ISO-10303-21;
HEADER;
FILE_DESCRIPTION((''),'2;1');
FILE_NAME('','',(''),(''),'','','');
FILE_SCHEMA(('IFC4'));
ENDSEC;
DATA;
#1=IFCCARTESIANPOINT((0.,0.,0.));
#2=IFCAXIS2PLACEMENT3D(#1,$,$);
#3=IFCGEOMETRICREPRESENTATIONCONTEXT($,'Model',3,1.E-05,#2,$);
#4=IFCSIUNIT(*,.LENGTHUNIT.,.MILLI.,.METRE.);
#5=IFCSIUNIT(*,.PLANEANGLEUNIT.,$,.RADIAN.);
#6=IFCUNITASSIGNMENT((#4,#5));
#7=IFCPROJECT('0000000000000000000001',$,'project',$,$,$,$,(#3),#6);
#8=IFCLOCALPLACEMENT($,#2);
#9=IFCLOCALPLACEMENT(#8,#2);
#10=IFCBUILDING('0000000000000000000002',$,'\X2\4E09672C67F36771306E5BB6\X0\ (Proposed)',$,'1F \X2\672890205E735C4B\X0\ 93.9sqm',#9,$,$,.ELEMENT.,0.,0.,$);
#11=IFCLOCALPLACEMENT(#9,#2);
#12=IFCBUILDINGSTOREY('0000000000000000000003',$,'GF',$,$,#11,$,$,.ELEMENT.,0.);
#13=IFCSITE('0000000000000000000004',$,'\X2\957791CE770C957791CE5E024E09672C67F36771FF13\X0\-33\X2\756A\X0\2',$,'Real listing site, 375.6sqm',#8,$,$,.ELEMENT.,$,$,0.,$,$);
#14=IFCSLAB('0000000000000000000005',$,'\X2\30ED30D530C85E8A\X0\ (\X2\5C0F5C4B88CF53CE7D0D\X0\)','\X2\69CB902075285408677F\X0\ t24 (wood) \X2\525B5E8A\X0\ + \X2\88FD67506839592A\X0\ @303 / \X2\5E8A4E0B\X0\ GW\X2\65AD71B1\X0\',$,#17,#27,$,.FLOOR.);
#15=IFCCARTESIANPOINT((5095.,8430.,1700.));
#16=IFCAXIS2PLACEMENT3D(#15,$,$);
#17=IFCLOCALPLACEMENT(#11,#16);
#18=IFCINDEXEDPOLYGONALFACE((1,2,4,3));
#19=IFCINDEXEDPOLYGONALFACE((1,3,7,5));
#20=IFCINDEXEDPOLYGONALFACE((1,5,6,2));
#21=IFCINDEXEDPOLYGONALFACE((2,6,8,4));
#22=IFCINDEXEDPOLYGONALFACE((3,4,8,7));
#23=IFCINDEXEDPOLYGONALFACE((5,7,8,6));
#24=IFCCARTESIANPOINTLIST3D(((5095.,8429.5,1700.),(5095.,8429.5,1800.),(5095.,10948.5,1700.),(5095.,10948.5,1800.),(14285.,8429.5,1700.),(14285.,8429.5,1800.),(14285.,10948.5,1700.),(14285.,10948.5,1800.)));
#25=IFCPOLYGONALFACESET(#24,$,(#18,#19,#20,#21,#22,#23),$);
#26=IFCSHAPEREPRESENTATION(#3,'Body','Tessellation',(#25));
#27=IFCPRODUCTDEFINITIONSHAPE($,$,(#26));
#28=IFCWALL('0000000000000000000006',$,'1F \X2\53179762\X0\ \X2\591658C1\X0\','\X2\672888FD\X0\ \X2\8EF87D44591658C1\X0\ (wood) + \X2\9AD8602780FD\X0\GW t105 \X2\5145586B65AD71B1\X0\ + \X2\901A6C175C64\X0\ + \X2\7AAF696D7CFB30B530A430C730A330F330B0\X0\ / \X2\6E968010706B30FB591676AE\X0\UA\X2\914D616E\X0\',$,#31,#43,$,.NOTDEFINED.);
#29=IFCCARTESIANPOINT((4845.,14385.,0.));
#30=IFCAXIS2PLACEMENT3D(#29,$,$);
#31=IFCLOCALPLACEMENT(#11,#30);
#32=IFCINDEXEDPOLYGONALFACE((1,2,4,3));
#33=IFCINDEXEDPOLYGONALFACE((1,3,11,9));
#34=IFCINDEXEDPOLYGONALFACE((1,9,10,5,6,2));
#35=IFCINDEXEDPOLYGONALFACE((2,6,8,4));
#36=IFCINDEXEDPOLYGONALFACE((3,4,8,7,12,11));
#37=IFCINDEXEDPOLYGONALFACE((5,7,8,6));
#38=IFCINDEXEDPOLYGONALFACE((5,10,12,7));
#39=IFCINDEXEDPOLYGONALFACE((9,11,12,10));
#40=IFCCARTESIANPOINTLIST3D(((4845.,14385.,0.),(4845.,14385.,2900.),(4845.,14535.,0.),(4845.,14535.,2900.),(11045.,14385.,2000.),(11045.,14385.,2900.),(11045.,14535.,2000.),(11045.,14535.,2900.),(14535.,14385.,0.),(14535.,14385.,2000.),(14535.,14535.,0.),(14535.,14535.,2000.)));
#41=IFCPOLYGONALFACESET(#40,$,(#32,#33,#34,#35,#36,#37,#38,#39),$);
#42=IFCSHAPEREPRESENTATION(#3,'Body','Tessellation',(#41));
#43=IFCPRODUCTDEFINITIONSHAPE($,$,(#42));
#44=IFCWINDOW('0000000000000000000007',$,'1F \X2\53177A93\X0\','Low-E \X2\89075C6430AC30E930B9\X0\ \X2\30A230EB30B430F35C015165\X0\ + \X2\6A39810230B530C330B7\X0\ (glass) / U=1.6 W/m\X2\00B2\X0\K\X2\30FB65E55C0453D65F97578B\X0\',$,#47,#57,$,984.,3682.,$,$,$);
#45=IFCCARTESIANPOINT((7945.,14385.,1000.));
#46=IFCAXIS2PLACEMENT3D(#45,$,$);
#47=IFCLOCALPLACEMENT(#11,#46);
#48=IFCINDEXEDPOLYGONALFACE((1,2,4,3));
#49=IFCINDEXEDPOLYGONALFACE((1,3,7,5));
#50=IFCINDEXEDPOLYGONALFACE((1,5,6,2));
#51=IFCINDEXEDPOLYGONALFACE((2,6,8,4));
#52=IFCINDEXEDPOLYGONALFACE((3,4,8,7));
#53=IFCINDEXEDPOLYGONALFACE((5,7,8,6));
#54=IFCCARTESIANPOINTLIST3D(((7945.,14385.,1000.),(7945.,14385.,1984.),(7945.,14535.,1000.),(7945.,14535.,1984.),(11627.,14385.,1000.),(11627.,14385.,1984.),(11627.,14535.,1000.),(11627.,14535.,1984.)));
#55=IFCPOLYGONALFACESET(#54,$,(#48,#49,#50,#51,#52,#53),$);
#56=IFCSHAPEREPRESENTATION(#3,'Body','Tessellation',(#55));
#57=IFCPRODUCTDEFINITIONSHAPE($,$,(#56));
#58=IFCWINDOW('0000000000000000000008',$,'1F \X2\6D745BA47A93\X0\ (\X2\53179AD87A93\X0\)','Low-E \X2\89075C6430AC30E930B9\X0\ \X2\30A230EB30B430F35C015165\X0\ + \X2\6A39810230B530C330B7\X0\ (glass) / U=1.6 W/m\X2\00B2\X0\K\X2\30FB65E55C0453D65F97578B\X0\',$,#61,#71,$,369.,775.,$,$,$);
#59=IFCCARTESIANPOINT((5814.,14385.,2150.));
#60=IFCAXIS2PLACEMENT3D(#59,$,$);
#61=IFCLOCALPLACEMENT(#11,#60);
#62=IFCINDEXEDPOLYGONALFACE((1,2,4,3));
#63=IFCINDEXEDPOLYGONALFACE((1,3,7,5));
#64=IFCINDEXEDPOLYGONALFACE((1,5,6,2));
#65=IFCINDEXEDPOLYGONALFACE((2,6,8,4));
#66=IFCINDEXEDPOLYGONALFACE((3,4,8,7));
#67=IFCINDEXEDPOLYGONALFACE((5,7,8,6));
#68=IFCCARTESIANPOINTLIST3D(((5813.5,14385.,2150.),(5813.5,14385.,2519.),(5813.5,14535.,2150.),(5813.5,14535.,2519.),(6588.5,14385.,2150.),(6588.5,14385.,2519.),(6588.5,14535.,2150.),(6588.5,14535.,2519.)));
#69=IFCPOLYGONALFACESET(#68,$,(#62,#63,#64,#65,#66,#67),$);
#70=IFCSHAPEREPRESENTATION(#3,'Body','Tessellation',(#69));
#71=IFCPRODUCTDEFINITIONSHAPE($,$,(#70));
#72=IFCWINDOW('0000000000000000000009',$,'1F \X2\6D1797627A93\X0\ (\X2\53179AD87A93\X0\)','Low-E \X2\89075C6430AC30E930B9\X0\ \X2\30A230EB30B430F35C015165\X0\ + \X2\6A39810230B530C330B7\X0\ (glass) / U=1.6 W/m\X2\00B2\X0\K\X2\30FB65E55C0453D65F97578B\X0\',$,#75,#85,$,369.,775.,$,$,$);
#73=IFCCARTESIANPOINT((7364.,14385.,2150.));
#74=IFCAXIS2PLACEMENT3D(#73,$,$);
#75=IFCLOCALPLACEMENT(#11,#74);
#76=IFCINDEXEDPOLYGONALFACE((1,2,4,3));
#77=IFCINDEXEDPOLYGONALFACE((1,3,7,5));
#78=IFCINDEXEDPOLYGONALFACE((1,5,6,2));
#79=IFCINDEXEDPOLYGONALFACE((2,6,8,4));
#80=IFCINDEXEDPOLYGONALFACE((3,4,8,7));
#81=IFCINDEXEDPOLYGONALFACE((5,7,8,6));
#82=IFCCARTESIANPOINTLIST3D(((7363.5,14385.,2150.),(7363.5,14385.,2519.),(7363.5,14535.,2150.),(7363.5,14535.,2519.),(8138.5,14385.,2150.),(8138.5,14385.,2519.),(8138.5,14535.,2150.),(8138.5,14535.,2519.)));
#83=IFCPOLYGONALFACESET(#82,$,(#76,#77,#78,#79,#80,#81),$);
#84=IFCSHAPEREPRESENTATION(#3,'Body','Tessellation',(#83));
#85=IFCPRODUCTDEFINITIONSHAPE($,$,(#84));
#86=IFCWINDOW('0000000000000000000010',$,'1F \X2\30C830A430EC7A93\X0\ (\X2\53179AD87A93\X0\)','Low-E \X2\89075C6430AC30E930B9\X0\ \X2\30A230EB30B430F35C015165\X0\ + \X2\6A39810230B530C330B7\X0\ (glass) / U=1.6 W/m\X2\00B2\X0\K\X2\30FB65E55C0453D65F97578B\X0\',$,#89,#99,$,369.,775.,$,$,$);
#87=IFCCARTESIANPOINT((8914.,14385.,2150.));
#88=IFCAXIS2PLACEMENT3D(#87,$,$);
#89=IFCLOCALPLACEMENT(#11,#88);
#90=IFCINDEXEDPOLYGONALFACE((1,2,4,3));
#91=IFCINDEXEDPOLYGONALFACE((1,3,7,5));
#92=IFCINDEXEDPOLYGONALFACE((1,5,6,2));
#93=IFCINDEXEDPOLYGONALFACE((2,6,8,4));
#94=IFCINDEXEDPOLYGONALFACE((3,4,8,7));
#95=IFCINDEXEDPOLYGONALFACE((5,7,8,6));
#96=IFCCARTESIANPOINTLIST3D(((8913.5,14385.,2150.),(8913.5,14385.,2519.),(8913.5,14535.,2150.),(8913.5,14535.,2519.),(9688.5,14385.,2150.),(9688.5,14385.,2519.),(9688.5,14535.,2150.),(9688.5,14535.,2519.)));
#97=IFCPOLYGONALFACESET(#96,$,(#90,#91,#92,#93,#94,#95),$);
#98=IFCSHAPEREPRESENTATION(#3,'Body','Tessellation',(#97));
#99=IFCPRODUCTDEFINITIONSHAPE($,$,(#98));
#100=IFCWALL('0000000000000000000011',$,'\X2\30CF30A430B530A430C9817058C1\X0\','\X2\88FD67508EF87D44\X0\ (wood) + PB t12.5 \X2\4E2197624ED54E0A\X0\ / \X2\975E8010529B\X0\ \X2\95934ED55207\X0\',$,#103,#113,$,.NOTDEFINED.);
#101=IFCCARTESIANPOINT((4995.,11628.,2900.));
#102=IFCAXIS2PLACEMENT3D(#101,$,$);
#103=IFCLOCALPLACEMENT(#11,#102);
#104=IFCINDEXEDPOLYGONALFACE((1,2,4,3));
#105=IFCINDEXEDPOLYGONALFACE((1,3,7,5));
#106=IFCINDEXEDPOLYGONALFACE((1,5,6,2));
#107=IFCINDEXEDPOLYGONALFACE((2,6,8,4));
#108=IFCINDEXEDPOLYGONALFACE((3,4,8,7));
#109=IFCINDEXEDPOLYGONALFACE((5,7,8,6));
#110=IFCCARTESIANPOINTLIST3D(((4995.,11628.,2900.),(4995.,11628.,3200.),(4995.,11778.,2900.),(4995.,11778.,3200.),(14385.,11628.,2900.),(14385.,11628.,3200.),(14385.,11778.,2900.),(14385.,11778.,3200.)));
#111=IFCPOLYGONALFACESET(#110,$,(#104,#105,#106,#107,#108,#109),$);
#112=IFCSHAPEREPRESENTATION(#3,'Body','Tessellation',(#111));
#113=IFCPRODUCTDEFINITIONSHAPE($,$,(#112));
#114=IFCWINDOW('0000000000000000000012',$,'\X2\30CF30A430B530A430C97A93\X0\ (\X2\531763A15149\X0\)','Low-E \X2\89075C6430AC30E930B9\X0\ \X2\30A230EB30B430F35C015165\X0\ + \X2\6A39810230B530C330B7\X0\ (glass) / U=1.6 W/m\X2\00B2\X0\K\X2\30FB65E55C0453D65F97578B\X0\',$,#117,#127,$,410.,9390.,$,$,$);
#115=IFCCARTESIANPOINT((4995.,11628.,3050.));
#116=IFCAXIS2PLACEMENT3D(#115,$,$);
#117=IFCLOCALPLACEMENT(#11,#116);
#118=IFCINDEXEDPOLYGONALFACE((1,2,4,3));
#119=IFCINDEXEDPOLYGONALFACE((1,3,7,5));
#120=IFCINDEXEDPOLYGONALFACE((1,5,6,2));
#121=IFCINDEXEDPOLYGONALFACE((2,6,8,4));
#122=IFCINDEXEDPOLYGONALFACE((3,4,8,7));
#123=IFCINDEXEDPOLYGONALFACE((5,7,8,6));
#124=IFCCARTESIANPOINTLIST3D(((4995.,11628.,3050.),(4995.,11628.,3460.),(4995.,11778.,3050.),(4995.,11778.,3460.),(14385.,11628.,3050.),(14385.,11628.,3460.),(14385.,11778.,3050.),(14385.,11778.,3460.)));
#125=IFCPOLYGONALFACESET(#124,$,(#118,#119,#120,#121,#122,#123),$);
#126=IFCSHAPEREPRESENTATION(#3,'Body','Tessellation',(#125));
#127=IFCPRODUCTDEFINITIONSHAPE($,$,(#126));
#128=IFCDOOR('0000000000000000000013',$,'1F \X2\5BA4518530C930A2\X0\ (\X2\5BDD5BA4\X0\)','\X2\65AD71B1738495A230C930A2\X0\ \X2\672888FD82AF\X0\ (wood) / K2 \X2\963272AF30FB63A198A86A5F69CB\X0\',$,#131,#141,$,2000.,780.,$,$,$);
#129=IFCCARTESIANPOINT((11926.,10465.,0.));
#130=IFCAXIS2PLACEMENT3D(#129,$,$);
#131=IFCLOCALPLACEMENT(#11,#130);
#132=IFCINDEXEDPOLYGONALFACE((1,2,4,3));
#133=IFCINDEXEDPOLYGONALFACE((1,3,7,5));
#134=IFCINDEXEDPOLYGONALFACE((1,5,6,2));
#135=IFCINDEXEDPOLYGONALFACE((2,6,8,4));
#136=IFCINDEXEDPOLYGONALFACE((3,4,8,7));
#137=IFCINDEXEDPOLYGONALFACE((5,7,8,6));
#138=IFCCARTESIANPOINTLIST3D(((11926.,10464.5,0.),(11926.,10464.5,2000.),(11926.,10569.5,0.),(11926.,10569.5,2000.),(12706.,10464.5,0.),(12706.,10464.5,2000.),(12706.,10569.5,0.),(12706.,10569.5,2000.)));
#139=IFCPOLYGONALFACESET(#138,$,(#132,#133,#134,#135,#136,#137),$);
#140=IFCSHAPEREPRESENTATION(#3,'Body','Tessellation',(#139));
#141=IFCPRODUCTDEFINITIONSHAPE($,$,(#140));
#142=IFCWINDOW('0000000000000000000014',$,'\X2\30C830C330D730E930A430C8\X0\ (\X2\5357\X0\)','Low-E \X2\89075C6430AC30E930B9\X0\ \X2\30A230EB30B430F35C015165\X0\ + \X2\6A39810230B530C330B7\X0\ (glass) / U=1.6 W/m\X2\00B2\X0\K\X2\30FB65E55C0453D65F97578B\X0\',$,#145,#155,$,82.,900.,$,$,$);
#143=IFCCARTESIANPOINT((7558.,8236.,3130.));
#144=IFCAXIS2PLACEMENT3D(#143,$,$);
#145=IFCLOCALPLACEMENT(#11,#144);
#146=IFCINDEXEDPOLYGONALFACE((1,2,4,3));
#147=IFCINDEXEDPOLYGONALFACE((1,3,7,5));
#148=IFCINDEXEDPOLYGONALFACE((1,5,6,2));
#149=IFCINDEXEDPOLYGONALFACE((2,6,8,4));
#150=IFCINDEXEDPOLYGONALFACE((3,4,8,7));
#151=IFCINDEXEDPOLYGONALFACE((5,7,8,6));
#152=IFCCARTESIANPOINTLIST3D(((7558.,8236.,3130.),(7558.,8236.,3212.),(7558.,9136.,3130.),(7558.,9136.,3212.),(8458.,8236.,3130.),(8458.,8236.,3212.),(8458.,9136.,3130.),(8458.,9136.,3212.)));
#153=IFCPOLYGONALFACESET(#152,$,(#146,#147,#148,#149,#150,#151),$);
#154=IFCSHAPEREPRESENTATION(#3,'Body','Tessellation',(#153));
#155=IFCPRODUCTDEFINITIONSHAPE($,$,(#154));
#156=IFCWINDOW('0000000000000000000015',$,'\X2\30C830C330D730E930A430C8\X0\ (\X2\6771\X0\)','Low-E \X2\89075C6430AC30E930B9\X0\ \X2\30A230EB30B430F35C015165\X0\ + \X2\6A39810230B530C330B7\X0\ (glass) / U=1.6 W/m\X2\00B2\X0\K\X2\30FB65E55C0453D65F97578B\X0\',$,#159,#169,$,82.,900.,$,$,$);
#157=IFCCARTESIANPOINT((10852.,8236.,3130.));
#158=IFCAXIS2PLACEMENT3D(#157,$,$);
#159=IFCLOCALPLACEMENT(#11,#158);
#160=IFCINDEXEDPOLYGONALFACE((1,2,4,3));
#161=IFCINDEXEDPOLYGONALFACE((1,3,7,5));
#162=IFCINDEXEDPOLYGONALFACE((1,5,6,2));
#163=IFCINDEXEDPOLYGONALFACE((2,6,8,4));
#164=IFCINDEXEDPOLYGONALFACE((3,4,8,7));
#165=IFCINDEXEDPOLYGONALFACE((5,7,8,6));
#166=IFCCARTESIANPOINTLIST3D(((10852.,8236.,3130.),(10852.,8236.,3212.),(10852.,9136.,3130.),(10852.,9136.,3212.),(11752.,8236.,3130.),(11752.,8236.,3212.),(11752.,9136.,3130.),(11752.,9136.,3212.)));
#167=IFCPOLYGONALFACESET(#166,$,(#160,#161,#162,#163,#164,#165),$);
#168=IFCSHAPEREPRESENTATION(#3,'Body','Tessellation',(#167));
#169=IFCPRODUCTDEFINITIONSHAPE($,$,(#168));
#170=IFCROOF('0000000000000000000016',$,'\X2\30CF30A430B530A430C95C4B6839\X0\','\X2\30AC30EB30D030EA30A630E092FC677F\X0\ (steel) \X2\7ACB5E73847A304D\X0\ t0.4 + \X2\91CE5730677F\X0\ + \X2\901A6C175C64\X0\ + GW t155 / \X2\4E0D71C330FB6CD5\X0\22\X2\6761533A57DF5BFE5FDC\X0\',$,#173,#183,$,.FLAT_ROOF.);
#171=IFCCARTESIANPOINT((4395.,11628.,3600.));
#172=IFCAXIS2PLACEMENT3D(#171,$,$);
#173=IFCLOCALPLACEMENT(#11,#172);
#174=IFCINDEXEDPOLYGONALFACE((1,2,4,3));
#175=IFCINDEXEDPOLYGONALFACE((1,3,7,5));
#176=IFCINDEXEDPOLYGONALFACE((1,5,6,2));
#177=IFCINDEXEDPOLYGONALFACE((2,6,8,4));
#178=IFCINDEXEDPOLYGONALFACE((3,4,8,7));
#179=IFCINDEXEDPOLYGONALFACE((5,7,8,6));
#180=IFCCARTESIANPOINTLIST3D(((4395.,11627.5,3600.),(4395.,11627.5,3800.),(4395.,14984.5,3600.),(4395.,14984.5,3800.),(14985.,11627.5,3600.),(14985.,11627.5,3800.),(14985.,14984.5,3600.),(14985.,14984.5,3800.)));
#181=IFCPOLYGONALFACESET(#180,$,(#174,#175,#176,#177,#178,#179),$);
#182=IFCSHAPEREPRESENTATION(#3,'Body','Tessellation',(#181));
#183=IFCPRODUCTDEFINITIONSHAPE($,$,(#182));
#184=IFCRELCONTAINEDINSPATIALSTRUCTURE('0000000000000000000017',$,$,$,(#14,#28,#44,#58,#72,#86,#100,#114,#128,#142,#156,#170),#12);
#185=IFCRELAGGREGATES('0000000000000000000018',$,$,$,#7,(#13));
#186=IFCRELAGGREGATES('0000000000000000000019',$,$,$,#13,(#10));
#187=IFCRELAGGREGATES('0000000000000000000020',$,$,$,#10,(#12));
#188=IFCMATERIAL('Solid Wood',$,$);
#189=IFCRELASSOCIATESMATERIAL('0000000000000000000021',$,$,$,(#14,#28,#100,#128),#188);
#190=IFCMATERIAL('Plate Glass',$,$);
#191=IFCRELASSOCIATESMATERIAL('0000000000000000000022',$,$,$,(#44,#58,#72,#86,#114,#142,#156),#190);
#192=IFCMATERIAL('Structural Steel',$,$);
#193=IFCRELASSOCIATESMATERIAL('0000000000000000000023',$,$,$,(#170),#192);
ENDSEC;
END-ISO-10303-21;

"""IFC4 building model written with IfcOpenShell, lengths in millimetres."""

from ifc_helpers import new_model, si_unit, frame, frame_2d, origin, place, context, project, spatial, rectangle, extrude, material, element, fill, save


model = new_model("IFC4")

# Units and contexts
model_context = context("Model", 3, precision=1e-05, world=origin())
ifc_project = project(units=[si_unit("LENGTHUNIT", "METRE", prefix="MILLI"), si_unit("PLANEANGLEUNIT", "RADIAN")], contexts=[model_context])

# Site, building, storey
site_placement = place(None, origin())
site = spatial("IfcSite", under=ifc_project, at=site_placement, Name="長野県長野市三本柳東３-33番2", ObjectType="Real listing site, 375.6sqm", CompositionType="ELEMENT", RefElevation=0.0)
building_placement = place(site_placement, origin())
building = spatial("IfcBuilding", under=site, at=building_placement, Name="三本柳東の家 (Proposed)", ObjectType="1F 木造平屋 93.9sqm", CompositionType="ELEMENT", ElevationOfRefHeight=0.0, ElevationOfTerrain=0.0)
storey_placement = place(building_placement, origin())
storey = spatial("IfcBuildingStorey", under=building, at=storey_placement, Name="GF", CompositionType="ELEMENT", Elevation=0.0)

# Slab
ifc_material_1 = material(Name="Solid Wood")
slab_placement = place(storey_placement, frame((5095.0, 8430.0, 1700.0)))
element("IfcSlab", 1, at=slab_placement, inside=storey, material=ifc_material_1, Name="ロフト床 (小屋裏収納)", Description="構造用合板 t24 (wood) 剛床 + 製材根太 @303 / 床下 GW断熱", PredefinedType="FLOOR", context=model_context, shape_type="SweptSolid", body=[
    extrude(rectangle(XDim=9190.0, YDim=2519.0, at=frame_2d((4595.0, 1259.0))), frame((5095.0, 8430.0, 1700.0)), (0.0, 0.0, 1.0), 100.0),
])

# Wall, openings, windows
wall_1_placement = place(storey_placement, frame((4845.0, 14385.0, 0.0)))
wall_1 = element("IfcWall", 2, at=wall_1_placement, inside=storey, material=ifc_material_1, Name="1F 北面 外壁", Description="木製 軸組外壁 (wood) + 高性能GW t105 充填断熱 + 通気層 + 窯業系サイディング / 準耐火・外皮UA配慮", PredefinedType="NOTDEFINED", context=model_context, shape_type="SweptSolid", body=[
    extrude(rectangle(XDim=9690.0, YDim=150.0, at=frame_2d((4845.0, 75.0))), frame((4845.0, 14385.0, 0.0)), (0.0, 0.0, 1.0), 2900.0),
])
opening_1_placement = place(storey_placement, frame((7945.0, 14385.0, 1000.0)))
opening_1 = element("IfcOpeningElement", 3, at=opening_1_placement, cuts=wall_1, PredefinedType="NOTDEFINED", context=model_context, shape_type="SweptSolid", body=[
    extrude(rectangle(XDim=3682.0, YDim=150.0, at=frame_2d((1841.0, 75.0))), frame((7945.0, 14385.0, 1000.0)), (0.0, 0.0, 1.0), 984.0),
])
opening_2_placement = place(storey_placement, frame((5814.0, 14385.0, 2150.0)))
opening_2 = element("IfcOpeningElement", 4, at=opening_2_placement, cuts=wall_1, PredefinedType="NOTDEFINED", context=model_context, shape_type="SweptSolid", body=[
    extrude(rectangle(XDim=775.0, YDim=150.0, at=frame_2d((387.0, 75.0))), frame((5814.0, 14385.0, 2150.0)), (0.0, 0.0, 1.0), 369.0),
])
opening_3_placement = place(storey_placement, frame((7364.0, 14385.0, 2150.0)))
opening_3 = element("IfcOpeningElement", 5, at=opening_3_placement, cuts=wall_1, PredefinedType="NOTDEFINED", context=model_context, shape_type="SweptSolid", body=[
    extrude(rectangle(XDim=775.0, YDim=150.0, at=frame_2d((387.0, 75.0))), frame((7364.0, 14385.0, 2150.0)), (0.0, 0.0, 1.0), 369.0),
])
opening_4_placement = place(storey_placement, frame((8914.0, 14385.0, 2150.0)))
opening_4 = element("IfcOpeningElement", 6, at=opening_4_placement, cuts=wall_1, PredefinedType="NOTDEFINED", context=model_context, shape_type="SweptSolid", body=[
    extrude(rectangle(XDim=775.0, YDim=150.0, at=frame_2d((387.0, 75.0))), frame((8914.0, 14385.0, 2150.0)), (0.0, 0.0, 1.0), 369.0),
])
ifc_material_2 = material(Name="Plate Glass")
window_1_placement = place(storey_placement, frame((7945.0, 14385.0, 1000.0)))
window_1 = element("IfcWindow", 7, at=window_1_placement, inside=storey, material=ifc_material_2, Name="1F 北窓", Description="Low-E 複層ガラス アルゴン封入 + 樹脂サッシ (glass) / U=1.6 W/m²K・日射取得型", OverallHeight=984.0, OverallWidth=3682.0, context=model_context, shape_type="SweptSolid", body=[
    extrude(rectangle(XDim=3682.0, YDim=150.0, at=frame_2d((1841.0, 75.0))), frame((7945.0, 14385.0, 1000.0)), (0.0, 0.0, 1.0), 984.0),
])
fill(opening_1, window_1)
window_2_placement = place(storey_placement, frame((5814.0, 14385.0, 2150.0)))
window_2 = element("IfcWindow", 8, at=window_2_placement, inside=storey, material=ifc_material_2, Name="1F 浴室窓 (北高窓)", Description="Low-E 複層ガラス アルゴン封入 + 樹脂サッシ (glass) / U=1.6 W/m²K・日射取得型", OverallHeight=369.0, OverallWidth=775.0, context=model_context, shape_type="SweptSolid", body=[
    extrude(rectangle(XDim=775.0, YDim=150.0, at=frame_2d((387.0, 75.0))), frame((5814.0, 14385.0, 2150.0)), (0.0, 0.0, 1.0), 369.0),
])
fill(opening_2, window_2)
window_3_placement = place(storey_placement, frame((7364.0, 14385.0, 2150.0)))
window_3 = element("IfcWindow", 9, at=window_3_placement, inside=storey, material=ifc_material_2, Name="1F 洗面窓 (北高窓)", Description="Low-E 複層ガラス アルゴン封入 + 樹脂サッシ (glass) / U=1.6 W/m²K・日射取得型", OverallHeight=369.0, OverallWidth=775.0, context=model_context, shape_type="SweptSolid", body=[
    extrude(rectangle(XDim=775.0, YDim=150.0, at=frame_2d((387.0, 75.0))), frame((7364.0, 14385.0, 2150.0)), (0.0, 0.0, 1.0), 369.0),
])
fill(opening_3, window_3)
window_4_placement = place(storey_placement, frame((8914.0, 14385.0, 2150.0)))
window_4 = element("IfcWindow", 10, at=window_4_placement, inside=storey, material=ifc_material_2, Name="1F トイレ窓 (北高窓)", Description="Low-E 複層ガラス アルゴン封入 + 樹脂サッシ (glass) / U=1.6 W/m²K・日射取得型", OverallHeight=369.0, OverallWidth=775.0, context=model_context, shape_type="SweptSolid", body=[
    extrude(rectangle(XDim=775.0, YDim=150.0, at=frame_2d((387.0, 75.0))), frame((8914.0, 14385.0, 2150.0)), (0.0, 0.0, 1.0), 369.0),
])
fill(opening_4, window_4)

# Wall, opening, window
wall_2_placement = place(storey_placement, frame((4995.0, 11628.0, 2900.0)))
wall_2 = element("IfcWall", 11, at=wall_2_placement, inside=storey, material=ifc_material_1, Name="ハイサイド腰壁", Description="製材軸組 (wood) + PB t12.5 両面仕上 / 非耐力 間仕切", PredefinedType="NOTDEFINED", context=model_context, shape_type="SweptSolid", body=[
    extrude(rectangle(XDim=9390.0, YDim=150.0, at=frame_2d((4695.0, 75.0))), frame((4995.0, 11628.0, 2900.0)), (0.0, 0.0, 1.0), 700.0),
])
opening_5_placement = place(storey_placement, frame((4995.0, 11628.0, 3050.0)))
opening_5 = element("IfcOpeningElement", 12, at=opening_5_placement, cuts=wall_2, PredefinedType="NOTDEFINED", context=model_context, shape_type="SweptSolid", body=[
    extrude(rectangle(XDim=9390.0, YDim=150.0, at=frame_2d((4695.0, 75.0))), frame((4995.0, 11628.0, 3050.0)), (0.0, 0.0, 1.0), 410.0),
])
window_5_placement = place(storey_placement, frame((4995.0, 11628.0, 3050.0)))
window_5 = element("IfcWindow", 13, at=window_5_placement, inside=storey, material=ifc_material_2, Name="ハイサイド窓 (北採光)", Description="Low-E 複層ガラス アルゴン封入 + 樹脂サッシ (glass) / U=1.6 W/m²K・日射取得型", OverallHeight=410.0, OverallWidth=9390.0, context=model_context, shape_type="SweptSolid", body=[
    extrude(rectangle(XDim=9390.0, YDim=150.0, at=frame_2d((4695.0, 75.0))), frame((4995.0, 11628.0, 3050.0)), (0.0, 0.0, 1.0), 410.0),
])
fill(opening_5, window_5)

# Door
door_1_placement = place(storey_placement, frame((11926.0, 10465.0, 0.0)))
element("IfcDoor", 14, at=door_1_placement, inside=storey, material=ifc_material_1, Name="1F 室内ドア (寝室)", Description="断熱玄関ドア 木製芯 (wood) / K2 防犯・採風機構", OverallHeight=2000.0, OverallWidth=780.0, context=model_context, shape_type="SweptSolid", body=[
    extrude(rectangle(XDim=780.0, YDim=105.0, at=frame_2d((390.0, 52.0))), frame((11926.0, 10465.0, 0.0)), (0.0, 0.0, 1.0), 2000.0),
])

# Windows
window_6_placement = place(storey_placement, frame((7558.0, 8236.0, 3130.0)))
element("IfcWindow", 15, at=window_6_placement, inside=storey, material=ifc_material_2, Name="トップライト (南)", Description="Low-E 複層ガラス アルゴン封入 + 樹脂サッシ (glass) / U=1.6 W/m²K・日射取得型", OverallHeight=82.0, OverallWidth=900.0, context=model_context, shape_type="SweptSolid", body=[
    extrude(rectangle(XDim=900.0, YDim=900.0, at=frame_2d((450.0, 450.0))), frame((7558.0, 8236.0, 3130.0)), (0.0, 0.0, 1.0), 82.0),
])
window_7_placement = place(storey_placement, frame((10852.0, 8236.0, 3130.0)))
element("IfcWindow", 16, at=window_7_placement, inside=storey, material=ifc_material_2, Name="トップライト (東)", Description="Low-E 複層ガラス アルゴン封入 + 樹脂サッシ (glass) / U=1.6 W/m²K・日射取得型", OverallHeight=82.0, OverallWidth=900.0, context=model_context, shape_type="SweptSolid", body=[
    extrude(rectangle(XDim=900.0, YDim=900.0, at=frame_2d((450.0, 450.0))), frame((10852.0, 8236.0, 3130.0)), (0.0, 0.0, 1.0), 82.0),
])

# Roof
ifc_material_3 = material(Name="Structural Steel")
roof_placement = place(storey_placement, frame((4395.0, 11628.0, 3600.0)))
element("IfcRoof", 17, at=roof_placement, inside=storey, material=ifc_material_3, Name="ハイサイド屋根", Description="ガルバリウム鋼板 (steel) 立平葺き t0.4 + 野地板 + 通気層 + GW t155 / 不燃・法22条区域対応", PredefinedType="FLAT_ROOF", context=model_context, shape_type="SweptSolid", body=[
    extrude(rectangle(XDim=10590.0, YDim=3357.0, at=frame_2d((5295.0, 1678.0))), frame((4395.0, 11628.0, 3600.0)), (0.0, 0.0, 1.0), 200.0),
])

save(model, "model.ifc")
